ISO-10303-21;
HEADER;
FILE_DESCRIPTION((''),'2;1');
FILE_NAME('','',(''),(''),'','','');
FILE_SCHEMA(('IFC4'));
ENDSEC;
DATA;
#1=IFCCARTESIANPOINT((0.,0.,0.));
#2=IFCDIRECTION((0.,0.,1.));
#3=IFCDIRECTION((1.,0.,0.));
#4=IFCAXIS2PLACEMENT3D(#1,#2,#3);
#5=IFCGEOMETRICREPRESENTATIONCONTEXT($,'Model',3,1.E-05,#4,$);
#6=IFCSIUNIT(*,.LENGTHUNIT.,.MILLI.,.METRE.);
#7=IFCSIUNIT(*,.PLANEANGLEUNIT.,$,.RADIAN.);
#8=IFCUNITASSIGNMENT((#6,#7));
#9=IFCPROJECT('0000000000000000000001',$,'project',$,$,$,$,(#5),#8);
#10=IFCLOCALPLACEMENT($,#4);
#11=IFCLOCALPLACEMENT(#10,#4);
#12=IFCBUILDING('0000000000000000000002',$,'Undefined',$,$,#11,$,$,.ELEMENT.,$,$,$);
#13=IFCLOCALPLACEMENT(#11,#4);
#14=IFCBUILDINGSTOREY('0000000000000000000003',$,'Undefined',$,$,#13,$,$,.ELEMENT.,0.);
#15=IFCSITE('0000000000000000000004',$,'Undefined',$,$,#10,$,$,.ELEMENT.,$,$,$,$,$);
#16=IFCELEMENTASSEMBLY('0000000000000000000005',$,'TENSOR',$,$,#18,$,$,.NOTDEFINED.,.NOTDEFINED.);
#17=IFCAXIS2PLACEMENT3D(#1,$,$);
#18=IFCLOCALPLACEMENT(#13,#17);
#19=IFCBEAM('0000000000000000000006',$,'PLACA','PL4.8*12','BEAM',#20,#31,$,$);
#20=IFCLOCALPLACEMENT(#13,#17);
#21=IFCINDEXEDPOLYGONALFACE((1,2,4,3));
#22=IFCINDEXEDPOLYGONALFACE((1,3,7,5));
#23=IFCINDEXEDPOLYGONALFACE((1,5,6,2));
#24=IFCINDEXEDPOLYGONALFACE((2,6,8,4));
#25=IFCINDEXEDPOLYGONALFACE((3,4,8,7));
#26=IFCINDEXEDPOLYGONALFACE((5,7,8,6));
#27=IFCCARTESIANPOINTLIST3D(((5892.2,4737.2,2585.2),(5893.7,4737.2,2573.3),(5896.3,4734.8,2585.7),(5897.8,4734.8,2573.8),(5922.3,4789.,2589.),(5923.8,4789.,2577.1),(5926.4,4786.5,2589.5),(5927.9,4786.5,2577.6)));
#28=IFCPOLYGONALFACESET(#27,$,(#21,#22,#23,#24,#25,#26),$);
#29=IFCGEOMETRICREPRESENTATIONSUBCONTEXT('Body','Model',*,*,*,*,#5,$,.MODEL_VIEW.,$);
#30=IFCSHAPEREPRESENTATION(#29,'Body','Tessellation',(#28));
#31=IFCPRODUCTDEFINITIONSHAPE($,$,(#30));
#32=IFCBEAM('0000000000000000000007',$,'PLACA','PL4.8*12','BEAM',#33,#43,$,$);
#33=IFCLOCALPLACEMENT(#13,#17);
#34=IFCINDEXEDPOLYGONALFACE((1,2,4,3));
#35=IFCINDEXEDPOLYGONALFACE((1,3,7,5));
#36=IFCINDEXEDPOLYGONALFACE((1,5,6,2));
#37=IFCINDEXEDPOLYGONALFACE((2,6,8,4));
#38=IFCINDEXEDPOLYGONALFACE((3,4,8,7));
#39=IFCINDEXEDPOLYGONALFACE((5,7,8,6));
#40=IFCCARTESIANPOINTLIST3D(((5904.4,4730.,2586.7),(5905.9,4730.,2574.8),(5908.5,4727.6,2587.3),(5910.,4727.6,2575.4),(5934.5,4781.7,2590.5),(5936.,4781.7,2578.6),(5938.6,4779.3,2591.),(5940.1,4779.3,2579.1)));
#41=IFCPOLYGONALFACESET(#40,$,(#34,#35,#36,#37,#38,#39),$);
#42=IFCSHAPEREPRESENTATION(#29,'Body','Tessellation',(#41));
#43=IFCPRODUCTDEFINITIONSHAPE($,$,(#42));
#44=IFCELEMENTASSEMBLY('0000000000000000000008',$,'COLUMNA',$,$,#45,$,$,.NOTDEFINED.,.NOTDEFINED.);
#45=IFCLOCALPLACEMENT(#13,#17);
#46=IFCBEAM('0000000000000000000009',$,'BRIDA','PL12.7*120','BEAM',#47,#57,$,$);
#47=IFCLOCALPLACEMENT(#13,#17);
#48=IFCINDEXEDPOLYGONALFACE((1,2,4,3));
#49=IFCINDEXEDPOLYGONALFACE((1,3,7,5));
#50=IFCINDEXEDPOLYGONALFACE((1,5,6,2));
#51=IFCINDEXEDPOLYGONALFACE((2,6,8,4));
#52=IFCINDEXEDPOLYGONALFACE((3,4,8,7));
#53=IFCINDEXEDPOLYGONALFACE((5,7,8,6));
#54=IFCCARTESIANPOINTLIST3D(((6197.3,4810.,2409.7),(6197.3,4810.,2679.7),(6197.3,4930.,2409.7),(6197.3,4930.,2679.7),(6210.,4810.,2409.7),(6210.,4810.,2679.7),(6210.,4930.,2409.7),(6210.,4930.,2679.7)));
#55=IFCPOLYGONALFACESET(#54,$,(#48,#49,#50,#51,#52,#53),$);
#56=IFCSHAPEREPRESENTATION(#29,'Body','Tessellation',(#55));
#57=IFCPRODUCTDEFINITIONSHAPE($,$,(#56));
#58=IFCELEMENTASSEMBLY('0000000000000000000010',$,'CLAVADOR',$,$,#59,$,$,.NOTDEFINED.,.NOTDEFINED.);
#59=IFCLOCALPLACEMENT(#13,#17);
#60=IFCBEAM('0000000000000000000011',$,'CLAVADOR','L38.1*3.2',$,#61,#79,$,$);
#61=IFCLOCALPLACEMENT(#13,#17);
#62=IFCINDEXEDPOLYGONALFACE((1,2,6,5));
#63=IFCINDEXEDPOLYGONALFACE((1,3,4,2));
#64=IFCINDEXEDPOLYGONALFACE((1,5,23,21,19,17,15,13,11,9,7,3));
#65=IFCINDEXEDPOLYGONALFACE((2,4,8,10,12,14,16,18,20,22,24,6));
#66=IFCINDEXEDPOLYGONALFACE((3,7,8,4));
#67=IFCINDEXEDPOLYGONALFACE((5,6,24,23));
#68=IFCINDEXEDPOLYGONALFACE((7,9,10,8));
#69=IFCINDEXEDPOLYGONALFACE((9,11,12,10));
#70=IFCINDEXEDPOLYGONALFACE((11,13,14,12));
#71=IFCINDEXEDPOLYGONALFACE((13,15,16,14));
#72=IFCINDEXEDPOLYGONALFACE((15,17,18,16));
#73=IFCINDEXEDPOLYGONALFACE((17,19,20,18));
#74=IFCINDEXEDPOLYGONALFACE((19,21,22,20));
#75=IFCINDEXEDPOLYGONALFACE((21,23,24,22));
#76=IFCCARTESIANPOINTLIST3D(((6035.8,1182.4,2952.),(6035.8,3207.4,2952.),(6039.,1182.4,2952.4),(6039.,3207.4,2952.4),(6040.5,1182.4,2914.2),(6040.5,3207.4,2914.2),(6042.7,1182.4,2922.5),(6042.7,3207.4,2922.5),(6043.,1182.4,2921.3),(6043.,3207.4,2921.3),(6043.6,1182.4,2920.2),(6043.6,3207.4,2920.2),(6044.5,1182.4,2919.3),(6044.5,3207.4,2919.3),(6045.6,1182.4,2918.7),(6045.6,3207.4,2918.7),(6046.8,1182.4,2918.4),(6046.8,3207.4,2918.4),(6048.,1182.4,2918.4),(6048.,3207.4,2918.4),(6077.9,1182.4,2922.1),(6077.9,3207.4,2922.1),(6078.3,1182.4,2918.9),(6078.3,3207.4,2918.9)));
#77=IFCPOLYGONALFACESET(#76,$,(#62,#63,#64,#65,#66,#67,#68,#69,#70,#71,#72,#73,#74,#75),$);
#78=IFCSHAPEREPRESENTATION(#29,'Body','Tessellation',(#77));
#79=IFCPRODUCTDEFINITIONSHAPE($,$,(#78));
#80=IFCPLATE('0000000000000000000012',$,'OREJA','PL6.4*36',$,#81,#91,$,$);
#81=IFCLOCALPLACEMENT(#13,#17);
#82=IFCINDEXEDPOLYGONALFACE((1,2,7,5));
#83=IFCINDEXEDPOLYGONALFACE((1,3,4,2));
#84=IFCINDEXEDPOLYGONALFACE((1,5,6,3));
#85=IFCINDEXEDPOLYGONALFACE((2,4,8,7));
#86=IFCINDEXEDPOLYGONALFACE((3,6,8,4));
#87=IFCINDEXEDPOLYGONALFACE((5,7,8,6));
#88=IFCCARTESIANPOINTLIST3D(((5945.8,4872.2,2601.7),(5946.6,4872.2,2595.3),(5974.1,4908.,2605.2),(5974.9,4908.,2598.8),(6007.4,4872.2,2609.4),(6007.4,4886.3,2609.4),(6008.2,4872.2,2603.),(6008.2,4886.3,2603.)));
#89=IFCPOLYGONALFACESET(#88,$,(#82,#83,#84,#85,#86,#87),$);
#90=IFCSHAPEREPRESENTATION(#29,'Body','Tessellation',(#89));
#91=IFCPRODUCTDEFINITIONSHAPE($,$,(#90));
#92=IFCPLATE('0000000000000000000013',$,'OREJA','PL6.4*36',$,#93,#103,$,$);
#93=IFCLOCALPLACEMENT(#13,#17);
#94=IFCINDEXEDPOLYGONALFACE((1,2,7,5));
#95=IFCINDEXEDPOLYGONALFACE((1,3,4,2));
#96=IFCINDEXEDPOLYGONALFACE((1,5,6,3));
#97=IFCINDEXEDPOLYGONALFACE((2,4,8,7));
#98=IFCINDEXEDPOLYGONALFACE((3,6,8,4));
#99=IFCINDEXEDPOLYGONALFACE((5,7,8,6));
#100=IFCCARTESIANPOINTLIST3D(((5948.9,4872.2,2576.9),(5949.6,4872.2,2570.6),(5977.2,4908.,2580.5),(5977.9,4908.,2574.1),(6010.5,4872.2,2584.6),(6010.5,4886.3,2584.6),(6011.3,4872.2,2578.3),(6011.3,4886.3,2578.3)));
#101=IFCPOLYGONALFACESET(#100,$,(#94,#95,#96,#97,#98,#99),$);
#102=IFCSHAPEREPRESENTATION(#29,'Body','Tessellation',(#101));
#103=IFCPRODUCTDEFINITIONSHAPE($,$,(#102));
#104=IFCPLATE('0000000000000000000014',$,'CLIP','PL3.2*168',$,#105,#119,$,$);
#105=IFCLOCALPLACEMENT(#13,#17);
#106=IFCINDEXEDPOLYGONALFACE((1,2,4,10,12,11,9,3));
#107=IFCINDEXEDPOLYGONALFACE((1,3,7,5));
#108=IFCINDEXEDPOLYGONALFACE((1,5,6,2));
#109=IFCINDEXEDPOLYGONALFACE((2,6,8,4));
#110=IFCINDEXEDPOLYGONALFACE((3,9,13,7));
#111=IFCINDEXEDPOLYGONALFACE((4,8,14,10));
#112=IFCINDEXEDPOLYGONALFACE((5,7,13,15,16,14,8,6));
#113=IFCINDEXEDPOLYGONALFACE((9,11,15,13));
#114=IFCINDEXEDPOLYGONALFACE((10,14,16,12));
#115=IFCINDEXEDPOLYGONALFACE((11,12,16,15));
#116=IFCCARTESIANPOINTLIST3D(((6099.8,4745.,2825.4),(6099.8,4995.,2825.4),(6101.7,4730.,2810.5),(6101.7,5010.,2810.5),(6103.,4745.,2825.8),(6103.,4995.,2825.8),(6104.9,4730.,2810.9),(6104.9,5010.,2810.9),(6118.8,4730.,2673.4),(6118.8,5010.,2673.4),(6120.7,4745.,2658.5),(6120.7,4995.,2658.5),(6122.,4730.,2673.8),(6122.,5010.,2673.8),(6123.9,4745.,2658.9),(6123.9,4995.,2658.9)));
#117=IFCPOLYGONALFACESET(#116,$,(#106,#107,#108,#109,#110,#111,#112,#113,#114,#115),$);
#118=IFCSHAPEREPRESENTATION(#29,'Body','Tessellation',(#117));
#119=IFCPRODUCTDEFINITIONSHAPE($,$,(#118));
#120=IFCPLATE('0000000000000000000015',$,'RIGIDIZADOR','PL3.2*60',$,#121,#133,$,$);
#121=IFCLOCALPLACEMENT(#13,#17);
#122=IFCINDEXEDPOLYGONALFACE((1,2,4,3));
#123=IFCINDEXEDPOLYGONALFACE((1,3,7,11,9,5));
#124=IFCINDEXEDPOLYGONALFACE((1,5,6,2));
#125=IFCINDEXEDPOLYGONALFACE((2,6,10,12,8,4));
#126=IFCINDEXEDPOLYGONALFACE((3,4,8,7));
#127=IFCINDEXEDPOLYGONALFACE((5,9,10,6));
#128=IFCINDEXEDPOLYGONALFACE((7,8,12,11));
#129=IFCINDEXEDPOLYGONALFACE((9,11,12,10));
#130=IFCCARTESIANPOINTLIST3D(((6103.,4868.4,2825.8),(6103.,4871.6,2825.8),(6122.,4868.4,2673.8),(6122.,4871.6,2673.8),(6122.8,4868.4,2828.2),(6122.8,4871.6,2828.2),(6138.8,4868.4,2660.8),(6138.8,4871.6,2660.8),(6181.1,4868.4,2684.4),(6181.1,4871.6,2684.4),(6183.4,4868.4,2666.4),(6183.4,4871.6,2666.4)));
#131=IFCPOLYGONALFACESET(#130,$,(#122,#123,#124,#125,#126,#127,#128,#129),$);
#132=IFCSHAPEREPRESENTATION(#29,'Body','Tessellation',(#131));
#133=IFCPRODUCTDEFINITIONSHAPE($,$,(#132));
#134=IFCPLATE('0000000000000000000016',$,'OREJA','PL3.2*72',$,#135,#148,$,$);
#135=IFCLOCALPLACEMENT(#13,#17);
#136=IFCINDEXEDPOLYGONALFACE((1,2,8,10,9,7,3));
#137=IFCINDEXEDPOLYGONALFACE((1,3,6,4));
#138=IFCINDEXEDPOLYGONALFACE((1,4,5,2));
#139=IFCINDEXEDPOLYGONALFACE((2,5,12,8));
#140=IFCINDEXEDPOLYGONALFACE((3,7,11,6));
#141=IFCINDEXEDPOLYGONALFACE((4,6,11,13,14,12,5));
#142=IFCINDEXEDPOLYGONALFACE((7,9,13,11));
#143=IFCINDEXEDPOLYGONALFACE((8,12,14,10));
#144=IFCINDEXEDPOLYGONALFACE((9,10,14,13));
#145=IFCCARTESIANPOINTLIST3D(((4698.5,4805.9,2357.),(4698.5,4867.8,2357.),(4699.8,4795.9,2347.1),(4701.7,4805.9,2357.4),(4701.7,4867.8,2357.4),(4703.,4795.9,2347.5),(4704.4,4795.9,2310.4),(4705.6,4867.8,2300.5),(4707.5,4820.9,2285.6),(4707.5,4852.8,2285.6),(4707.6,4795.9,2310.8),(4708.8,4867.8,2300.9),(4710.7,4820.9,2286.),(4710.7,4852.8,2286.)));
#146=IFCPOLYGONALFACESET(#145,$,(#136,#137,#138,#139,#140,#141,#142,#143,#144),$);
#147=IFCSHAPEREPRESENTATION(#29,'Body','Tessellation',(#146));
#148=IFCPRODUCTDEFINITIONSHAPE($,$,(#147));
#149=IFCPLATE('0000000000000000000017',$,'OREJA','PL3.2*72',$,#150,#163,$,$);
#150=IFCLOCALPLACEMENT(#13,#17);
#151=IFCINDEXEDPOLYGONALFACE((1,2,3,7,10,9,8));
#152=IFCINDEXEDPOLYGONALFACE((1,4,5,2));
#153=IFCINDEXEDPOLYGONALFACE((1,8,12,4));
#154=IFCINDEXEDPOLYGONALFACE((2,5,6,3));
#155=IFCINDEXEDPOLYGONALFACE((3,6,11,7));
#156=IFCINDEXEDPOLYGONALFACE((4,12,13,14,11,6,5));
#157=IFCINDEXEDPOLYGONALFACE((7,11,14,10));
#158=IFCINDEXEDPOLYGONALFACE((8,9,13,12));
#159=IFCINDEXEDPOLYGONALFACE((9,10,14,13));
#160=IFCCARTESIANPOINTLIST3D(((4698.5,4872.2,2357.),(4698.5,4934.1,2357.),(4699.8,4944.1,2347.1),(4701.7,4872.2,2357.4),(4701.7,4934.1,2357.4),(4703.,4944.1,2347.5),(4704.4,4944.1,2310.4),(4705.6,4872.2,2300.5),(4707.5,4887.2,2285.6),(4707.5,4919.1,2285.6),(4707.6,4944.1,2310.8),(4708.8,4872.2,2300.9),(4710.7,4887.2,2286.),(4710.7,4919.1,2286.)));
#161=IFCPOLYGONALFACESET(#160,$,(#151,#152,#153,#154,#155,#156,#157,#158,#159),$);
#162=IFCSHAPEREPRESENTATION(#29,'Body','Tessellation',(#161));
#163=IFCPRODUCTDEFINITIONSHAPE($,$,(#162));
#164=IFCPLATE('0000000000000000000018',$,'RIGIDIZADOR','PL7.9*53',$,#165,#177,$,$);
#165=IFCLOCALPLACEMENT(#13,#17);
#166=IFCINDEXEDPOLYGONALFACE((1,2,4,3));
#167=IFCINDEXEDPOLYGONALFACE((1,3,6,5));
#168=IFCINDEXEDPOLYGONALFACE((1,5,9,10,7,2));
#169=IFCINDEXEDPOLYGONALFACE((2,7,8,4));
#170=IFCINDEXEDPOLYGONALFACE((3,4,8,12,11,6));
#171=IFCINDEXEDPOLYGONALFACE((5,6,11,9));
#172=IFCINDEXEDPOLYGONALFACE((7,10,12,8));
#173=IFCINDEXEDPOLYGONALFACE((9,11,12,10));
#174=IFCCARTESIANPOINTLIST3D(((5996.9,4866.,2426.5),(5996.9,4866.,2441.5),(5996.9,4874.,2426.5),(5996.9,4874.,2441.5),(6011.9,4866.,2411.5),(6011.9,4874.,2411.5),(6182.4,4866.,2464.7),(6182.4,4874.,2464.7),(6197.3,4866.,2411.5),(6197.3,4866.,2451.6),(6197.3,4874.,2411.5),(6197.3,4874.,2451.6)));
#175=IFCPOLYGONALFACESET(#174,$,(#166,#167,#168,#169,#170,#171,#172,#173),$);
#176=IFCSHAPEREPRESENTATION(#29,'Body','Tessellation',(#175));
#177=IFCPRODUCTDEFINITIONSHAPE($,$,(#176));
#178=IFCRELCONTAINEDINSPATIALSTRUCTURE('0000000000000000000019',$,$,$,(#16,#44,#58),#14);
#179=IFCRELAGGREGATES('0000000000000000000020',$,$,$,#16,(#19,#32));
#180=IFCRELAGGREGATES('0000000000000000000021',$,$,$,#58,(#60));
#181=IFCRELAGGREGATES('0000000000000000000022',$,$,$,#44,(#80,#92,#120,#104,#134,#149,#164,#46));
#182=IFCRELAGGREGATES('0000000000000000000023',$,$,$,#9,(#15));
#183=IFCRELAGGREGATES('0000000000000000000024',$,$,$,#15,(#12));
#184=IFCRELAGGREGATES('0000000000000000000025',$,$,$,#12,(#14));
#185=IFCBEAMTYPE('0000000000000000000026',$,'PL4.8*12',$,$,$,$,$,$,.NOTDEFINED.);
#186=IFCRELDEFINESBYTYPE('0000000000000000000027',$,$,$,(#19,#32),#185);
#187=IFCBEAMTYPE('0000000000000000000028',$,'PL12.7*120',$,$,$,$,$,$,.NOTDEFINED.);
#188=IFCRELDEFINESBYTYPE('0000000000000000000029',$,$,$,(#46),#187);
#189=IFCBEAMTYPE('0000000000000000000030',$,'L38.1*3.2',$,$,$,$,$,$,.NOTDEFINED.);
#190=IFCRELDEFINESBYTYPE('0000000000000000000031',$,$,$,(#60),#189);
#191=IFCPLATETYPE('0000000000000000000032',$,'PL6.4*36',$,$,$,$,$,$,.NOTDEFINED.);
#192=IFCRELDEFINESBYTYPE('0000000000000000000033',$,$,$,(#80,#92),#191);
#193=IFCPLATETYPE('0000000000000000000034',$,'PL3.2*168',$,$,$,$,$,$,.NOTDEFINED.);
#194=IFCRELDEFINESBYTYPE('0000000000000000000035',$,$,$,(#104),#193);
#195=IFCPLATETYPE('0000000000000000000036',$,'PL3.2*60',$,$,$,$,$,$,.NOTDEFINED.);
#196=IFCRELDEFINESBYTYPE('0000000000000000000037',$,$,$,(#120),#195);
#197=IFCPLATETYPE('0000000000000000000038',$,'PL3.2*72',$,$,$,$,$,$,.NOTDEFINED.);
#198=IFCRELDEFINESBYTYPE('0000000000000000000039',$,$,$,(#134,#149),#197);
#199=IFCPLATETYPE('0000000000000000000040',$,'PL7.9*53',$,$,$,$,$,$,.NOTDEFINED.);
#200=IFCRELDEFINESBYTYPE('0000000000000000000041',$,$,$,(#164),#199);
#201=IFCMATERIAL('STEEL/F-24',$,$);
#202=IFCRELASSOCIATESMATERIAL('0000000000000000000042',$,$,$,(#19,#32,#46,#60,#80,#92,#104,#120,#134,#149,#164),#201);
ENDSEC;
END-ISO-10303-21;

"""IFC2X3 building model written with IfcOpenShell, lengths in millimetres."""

from ifc_helpers import new_model, si_unit, frame, origin_with_axes, origin_2d_with_axis, place, context, subcontext, project, spatial, polyline, rectangle, l_section, outline, extrude, material, type_object, element, aggregate, save


model = new_model("IFC2X3")

# Units and contexts
model_context = context("Model", 3, precision=1e-05, world=origin_with_axes())
body_context = subcontext(model_context, "Body", "Model", "MODEL_VIEW")
ifc_project = project(units=[si_unit("LENGTHUNIT", "METRE", prefix="MILLI"), si_unit("PLANEANGLEUNIT", "RADIAN")], contexts=[model_context])

# Site, building, storey
site_placement = place(None, origin_with_axes())
site = spatial("IfcSite", under=ifc_project, at=site_placement, Name="Undefined", CompositionType="ELEMENT")
building_placement = place(site_placement, origin_with_axes())
building = spatial("IfcBuilding", under=site, at=building_placement, Name="Undefined", CompositionType="ELEMENT")
storey_placement = place(building_placement, origin_with_axes())
storey = spatial("IfcBuildingStorey", under=building, at=storey_placement, Name="Undefined", CompositionType="ELEMENT", Elevation=0.0)

# Element assembly, beams
assembly_1_placement = place(storey_placement, origin_with_axes())
assembly_1 = element("IfcElementAssembly", 1, at=assembly_1_placement, inside=storey, Name="TENSOR", AssemblyPlace="NOTDEFINED", PredefinedType="NOTDEFINED")
ifc_material_1 = material(Name="STEEL/F-24")
beam_type_1 = type_object("IfcBeamType", Name="PL4.8*12", PredefinedType="NOTDEFINED")
beam_1_placement = place(assembly_1_placement, frame((5895.0, 4736.0, 2579.5), z_axis=(0.124075, 0.0, -0.992273), x_axis=(0.50206, 0.862551, 0.062778)))
beam_1 = element("IfcBeam", 2, at=beam_1_placement, type_object=beam_type_1, material=ifc_material_1, Name="PLACA", Description="PL4.8*12", ObjectType="BEAM", context=body_context, shape_type="SweptSolid", body=[
    extrude(rectangle(XDim=4.8, YDim=12.0, at=origin_2d_with_axis()), frame((60.0, 0.0, 0.0), z_axis=(-1.0, 0.0, 0.0), x_axis=(0.0, -1.0, 0.0)), (0.0, 0.0, 1.0), 60.0),
])
beam_2_placement = place(assembly_1_placement, frame((5907.2, 4728.8, 2581.1), z_axis=(0.124075, 0.0, -0.992273), x_axis=(0.50206, 0.862551, 0.062778)))
beam_2 = element("IfcBeam", 3, at=beam_2_placement, type_object=beam_type_1, material=ifc_material_1, Name="PLACA", Description="PL4.8*12", ObjectType="BEAM", context=body_context, shape_type="SweptSolid", body=[
    extrude(rectangle(XDim=4.8, YDim=12.0, at=origin_2d_with_axis()), frame((60.0, 0.0, 0.0), z_axis=(-1.0, 0.0, 0.0), x_axis=(0.0, -1.0, 0.0)), (0.0, 0.0, 1.0), 60.0),
])
aggregate(assembly_1, [beam_1, beam_2])

# Element assemblies, beams
assembly_2_placement = place(storey_placement, origin_with_axes())
assembly_2 = element("IfcElementAssembly", 4, at=assembly_2_placement, inside=storey, Name="COLUMNA", AssemblyPlace="NOTDEFINED", PredefinedType="NOTDEFINED")
beam_type_2 = type_object("IfcBeamType", Name="PL12.7*120", PredefinedType="NOTDEFINED")
beam_3_placement = place(assembly_2_placement, frame((6203.7, 4870.0, 2679.7), z_axis=(0.0, -1.0, 0.0), x_axis=(0.0, 0.000001, -1.0)))
beam_3 = element("IfcBeam", 5, at=beam_3_placement, type_object=beam_type_2, material=ifc_material_1, Name="BRIDA", Description="PL12.7*120", ObjectType="BEAM", context=body_context, shape_type="SweptSolid", body=[
    extrude(rectangle(XDim=12.7, YDim=120.0, at=origin_2d_with_axis()), frame((270.0, 0.0, 0.0), z_axis=(-1.0, 0.0, 0.0), x_axis=(0.0, -1.0, 0.0)), (0.0, 0.0, 1.0), 270.0),
])
assembly_3_placement = place(storey_placement, origin_with_axes())
assembly_3 = element("IfcElementAssembly", 6, at=assembly_3_placement, inside=storey, Name="CLAVADOR", AssemblyPlace="NOTDEFINED", PredefinedType="NOTDEFINED")
beam_type_3 = type_object("IfcBeamType", Name="L38.1*3.2", PredefinedType="NOTDEFINED")
beam_4_placement = place(assembly_3_placement, frame((6057.0, 3207.4, 2935.5), z_axis=(0.992273, 0.0, 0.124075), x_axis=(0.0, -1.0, 0.0)))
beam_4 = element("IfcBeam", 7, at=beam_4_placement, type_object=beam_type_3, material=ifc_material_1, Name="CLAVADOR", Description="L38.1*3.2", context=body_context, shape_type="SweptSolid", body=[
    extrude(l_section(Depth=38.1, Width=38.1, Thickness=3.2, FilletRadius=4.8, at=origin_2d_with_axis()), frame((2025.0, 0.0, 0.0), z_axis=(-1.0, 0.0, 0.0), x_axis=(0.0, -1.0, 0.0)), (0.0, 0.0, 1.0), 2025.0),
])
aggregate(assembly_3, [beam_4])

# Plates
plate_type_1 = type_object("IfcPlateType", Name="PL6.4*36", PredefinedType="NOTDEFINED")
plate_1_placement = place(assembly_2_placement, frame((6007.8, 4872.2, 2606.2), z_axis=(0.124075, 0.0, -0.992273), x_axis=(-0.992273, 0.0, -0.124075)))
plate_1 = element("IfcPlate", 8, at=plate_1_placement, type_object=plate_type_1, material=ifc_material_1, Name="OREJA", Description="PL6.4*36", context=body_context, shape_type="SweptSolid", body=[
    extrude(outline(polyline([(0.0, 0.0), (62.1, 0.0), (33.6, 35.8), (0.0, 14.0), (0.0, 0.0)])), frame((0.0, 0.0, -3.2), z_axis=(0.0, 0.0, 1.0), x_axis=(1.0, 0.0, 0.0)), (0.0, 0.0, 1.0), 6.4),
])
plate_2_placement = place(assembly_2_placement, frame((6010.9, 4872.2, 2581.5), z_axis=(0.124075, 0.0, -0.992273), x_axis=(-0.992273, 0.0, -0.124075)))
plate_2 = element("IfcPlate", 9, at=plate_2_placement, type_object=plate_type_1, material=ifc_material_1, Name="OREJA", Description="PL6.4*36", context=body_context, shape_type="SweptSolid", body=[
    extrude(outline(polyline([(0.0, 0.0), (62.1, 0.0), (33.6, 35.8), (0.0, 14.0), (0.0, 0.0)])), frame((0.0, 0.0, -3.2), z_axis=(0.0, 0.0, 1.0), x_axis=(1.0, 0.0, 0.0)), (0.0, 0.0, 1.0), 6.4),
])
plate_type_2 = type_object("IfcPlateType", Name="PL3.2*168", PredefinedType="NOTDEFINED")
plate_3_placement = place(assembly_2_placement, frame((6101.4, 4730.0, 2825.6), z_axis=(-0.992271, 0.0, -0.124089), x_axis=(0.0, 1.0, 0.0)))
plate_3 = element("IfcPlate", 10, at=plate_3_placement, type_object=plate_type_2, material=ifc_material_1, Name="CLIP", Description="PL3.2*168", context=body_context, shape_type="SweptSolid", body=[
    extrude(outline(polyline([(0.0, 15.0), (15.0, 0.0), (265.0, 0.0), (280.0, 15.0), (280.0, 153.1), (265.0, 168.1), (15.0, 168.1), (0.0, 153.1), (0.0, 15.0)])), frame((0.0, 0.0, -1.6), z_axis=(0.0, 0.0, 1.0), x_axis=(1.0, 0.0, 0.0)), (0.0, 0.0, 1.0), 3.2),
])
plate_type_3 = type_object("IfcPlateType", Name="PL3.2*60", PredefinedType="NOTDEFINED")
plate_4_placement = place(assembly_2_placement, frame((6103.0, 4870.0, 2825.8), z_axis=(0.0, 1.0, 0.0), x_axis=(0.992245, 0.0, 0.124299)))
plate_4 = element("IfcPlate", 11, at=plate_4_placement, type_object=plate_type_3, material=ifc_material_1, Name="RIGIDIZADOR", Description="PL3.2*60", context=body_context, shape_type="SweptSolid", body=[
    extrude(outline(polyline([(0.0, 0.0), (20.0, 0.0), (60.0, 150.0), (60.0, 168.1), (15.0, 168.1), (0.0, 153.1), (0.0, 0.0)])), frame((0.0, 0.0, -1.6), z_axis=(0.0, 0.0, 1.0), x_axis=(1.0, 0.0, 0.0)), (0.0, 0.0, 1.0), 3.2),
])
plate_type_4 = type_object("IfcPlateType", Name="PL3.2*72", PredefinedType="NOTDEFINED")
plate_5_placement = place(assembly_2_placement, frame((4709.1, 4867.8, 2285.8), z_axis=(-0.992251, 0.0, -0.124252), x_axis=(0.0, -1.0, 0.0)))
plate_5 = element("IfcPlate", 12, at=plate_5_placement, type_object=plate_type_4, material=ifc_material_1, Name="OREJA", Description="PL3.2*72", context=body_context, shape_type="SweptSolid", body=[
    extrude(outline(polyline([(0.0, 15.0), (15.0, 0.0), (47.0, 0.0), (72.0, 25.0), (72.0, 62.0), (62.0, 72.0), (0.0, 72.0), (0.0, 15.0)])), frame((0.0, 0.0, -1.6), z_axis=(0.0, 0.0, 1.0), x_axis=(1.0, 0.0, 0.0)), (0.0, 0.0, 1.0), 3.2),
])
plate_6_placement = place(assembly_2_placement, frame((4709.1, 4872.2, 2285.8), z_axis=(0.992251, 0.0, 0.124252), x_axis=(0.0, 1.0, 0.0)))
plate_6 = element("IfcPlate", 13, at=plate_6_placement, type_object=plate_type_4, material=ifc_material_1, Name="OREJA", Description="PL3.2*72", context=body_context, shape_type="SweptSolid", body=[
    extrude(outline(polyline([(0.0, 15.0), (15.0, 0.0), (47.0, 0.0), (72.0, 25.0), (72.0, 62.0), (62.0, 72.0), (0.0, 72.0), (0.0, 15.0)])), frame((0.0, 0.0, -1.6), z_axis=(0.0, 0.0, 1.0), x_axis=(1.0, 0.0, 0.0)), (0.0, 0.0, 1.0), 3.2),
])
plate_type_5 = type_object("IfcPlateType", Name="PL7.9*53", PredefinedType="NOTDEFINED")
plate_7_placement = place(assembly_2_placement, frame((5996.9, 4870.0, 2441.5), z_axis=(0.0, -1.0, 0.0), x_axis=(0.0, 0.000001, -1.0)))
plate_7 = element("IfcPlate", 14, at=plate_7_placement, type_object=plate_type_5, material=ifc_material_1, Name="RIGIDIZADOR", Description="PL7.9*53", context=body_context, shape_type="SweptSolid", body=[
    extrude(outline(polyline([(0.0, 0.0), (15.0, 0.0), (30.0, 15.0), (30.0, 200.4), (-10.1, 200.4), (-23.2, 185.5), (0.0, 0.0)])), frame((0.0, 0.0, -4.0), z_axis=(0.0, 0.0, 1.0), x_axis=(1.0, 0.0, 0.0)), (0.0, 0.0, 1.0), 7.9),
])

aggregate(assembly_2, [plate_1, plate_2, plate_4, plate_3, plate_5, plate_6, plate_7, beam_3])

save(model, "model.ifc")
